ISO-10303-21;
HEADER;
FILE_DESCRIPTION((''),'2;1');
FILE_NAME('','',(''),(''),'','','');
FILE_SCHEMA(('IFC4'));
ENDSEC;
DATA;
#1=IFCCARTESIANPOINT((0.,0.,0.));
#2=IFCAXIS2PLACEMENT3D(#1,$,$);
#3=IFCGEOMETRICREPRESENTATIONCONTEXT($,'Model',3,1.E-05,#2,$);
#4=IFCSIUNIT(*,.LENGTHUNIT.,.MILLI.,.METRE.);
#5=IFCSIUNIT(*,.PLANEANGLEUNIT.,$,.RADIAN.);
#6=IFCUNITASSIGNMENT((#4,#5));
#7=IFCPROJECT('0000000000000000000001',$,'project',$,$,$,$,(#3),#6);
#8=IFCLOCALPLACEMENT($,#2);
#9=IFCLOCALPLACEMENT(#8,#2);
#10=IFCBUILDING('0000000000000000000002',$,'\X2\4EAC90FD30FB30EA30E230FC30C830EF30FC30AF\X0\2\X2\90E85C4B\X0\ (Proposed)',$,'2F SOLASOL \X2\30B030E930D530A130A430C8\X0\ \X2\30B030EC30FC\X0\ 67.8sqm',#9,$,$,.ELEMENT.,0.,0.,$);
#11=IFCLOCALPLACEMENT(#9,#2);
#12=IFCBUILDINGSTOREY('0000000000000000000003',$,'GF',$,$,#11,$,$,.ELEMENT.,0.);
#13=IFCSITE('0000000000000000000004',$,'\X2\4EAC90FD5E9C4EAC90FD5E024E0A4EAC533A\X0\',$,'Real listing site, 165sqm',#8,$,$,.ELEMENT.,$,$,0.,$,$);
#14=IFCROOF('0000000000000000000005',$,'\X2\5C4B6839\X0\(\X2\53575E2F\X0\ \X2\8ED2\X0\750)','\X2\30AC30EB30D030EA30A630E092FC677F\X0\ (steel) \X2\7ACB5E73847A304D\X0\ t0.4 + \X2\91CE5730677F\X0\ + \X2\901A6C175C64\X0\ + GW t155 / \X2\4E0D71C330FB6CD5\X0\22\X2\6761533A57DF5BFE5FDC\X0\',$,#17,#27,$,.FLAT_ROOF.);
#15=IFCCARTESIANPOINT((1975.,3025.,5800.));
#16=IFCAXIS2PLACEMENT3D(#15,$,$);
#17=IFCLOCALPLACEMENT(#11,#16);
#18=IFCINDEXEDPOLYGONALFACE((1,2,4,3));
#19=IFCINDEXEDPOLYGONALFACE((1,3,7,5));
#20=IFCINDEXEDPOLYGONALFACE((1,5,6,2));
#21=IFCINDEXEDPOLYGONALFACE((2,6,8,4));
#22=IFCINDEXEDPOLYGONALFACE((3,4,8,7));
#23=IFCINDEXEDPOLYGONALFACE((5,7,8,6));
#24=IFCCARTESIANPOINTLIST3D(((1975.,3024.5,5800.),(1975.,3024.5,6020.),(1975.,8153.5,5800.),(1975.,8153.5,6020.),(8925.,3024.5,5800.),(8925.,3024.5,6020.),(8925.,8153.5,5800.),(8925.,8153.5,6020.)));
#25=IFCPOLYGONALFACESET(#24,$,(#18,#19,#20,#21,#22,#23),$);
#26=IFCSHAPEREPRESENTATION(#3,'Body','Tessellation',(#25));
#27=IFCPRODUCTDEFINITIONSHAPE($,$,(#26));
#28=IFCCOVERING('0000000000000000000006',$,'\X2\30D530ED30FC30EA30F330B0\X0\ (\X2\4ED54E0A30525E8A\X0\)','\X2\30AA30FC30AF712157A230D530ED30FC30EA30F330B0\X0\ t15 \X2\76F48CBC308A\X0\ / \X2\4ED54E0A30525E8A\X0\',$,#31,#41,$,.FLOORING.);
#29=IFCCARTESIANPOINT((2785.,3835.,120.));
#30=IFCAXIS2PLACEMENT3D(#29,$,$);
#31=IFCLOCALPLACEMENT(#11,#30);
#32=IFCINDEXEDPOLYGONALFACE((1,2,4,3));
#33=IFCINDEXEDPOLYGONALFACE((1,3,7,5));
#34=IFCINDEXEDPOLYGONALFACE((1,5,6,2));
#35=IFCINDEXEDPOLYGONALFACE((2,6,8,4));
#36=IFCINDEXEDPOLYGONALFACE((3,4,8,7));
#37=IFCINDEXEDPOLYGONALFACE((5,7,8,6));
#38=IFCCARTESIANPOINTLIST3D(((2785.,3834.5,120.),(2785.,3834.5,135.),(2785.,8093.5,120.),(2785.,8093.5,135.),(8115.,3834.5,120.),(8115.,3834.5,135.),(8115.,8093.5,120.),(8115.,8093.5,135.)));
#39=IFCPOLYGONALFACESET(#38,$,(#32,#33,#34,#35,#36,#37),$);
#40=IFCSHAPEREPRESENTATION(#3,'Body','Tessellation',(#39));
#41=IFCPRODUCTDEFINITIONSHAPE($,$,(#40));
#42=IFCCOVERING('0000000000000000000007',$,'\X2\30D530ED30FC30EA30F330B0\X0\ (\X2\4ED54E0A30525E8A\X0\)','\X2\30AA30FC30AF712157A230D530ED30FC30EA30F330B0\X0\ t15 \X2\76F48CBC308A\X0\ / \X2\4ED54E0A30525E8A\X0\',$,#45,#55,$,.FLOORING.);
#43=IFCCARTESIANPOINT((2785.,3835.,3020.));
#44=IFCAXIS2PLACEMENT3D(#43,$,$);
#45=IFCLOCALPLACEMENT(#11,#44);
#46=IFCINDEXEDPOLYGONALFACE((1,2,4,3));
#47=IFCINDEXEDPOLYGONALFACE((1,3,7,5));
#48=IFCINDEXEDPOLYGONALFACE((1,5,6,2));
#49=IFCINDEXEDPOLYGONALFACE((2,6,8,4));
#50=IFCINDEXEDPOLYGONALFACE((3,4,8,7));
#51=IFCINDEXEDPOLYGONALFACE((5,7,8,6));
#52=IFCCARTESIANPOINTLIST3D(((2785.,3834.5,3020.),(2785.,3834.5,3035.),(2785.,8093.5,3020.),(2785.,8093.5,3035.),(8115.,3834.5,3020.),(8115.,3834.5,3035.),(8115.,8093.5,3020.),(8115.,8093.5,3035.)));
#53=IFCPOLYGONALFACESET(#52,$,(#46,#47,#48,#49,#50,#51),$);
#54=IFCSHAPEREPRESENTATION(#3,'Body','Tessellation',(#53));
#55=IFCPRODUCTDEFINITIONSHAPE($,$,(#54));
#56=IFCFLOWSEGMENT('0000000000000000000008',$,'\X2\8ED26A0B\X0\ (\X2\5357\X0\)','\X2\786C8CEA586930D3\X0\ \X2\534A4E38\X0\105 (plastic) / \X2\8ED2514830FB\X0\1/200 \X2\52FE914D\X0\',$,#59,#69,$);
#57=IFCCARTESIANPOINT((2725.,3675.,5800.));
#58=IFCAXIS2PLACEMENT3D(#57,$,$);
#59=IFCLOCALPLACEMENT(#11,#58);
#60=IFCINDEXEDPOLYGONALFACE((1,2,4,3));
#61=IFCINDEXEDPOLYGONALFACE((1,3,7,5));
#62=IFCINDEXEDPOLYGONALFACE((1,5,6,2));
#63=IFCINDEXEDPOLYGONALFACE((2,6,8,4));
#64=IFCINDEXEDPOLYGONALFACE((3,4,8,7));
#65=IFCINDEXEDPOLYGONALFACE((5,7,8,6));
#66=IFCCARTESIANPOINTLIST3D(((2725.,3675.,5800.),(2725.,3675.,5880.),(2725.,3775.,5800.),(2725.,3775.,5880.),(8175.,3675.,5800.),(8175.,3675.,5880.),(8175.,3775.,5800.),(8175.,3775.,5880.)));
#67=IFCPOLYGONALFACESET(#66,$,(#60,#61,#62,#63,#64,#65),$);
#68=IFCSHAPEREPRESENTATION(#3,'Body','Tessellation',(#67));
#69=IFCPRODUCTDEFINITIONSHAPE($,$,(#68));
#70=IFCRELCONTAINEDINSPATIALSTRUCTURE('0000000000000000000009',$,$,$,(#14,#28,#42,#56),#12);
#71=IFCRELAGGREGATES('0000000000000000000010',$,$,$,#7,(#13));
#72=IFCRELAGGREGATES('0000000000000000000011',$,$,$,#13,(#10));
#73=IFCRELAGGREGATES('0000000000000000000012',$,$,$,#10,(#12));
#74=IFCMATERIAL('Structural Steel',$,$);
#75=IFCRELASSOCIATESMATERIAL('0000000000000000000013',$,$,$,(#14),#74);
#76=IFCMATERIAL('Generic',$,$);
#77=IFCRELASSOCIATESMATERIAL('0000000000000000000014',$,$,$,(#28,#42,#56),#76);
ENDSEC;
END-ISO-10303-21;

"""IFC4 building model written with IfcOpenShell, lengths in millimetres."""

from ifc_helpers import new_model, si_unit, frame, frame_2d, origin, place, context, project, spatial, rectangle, extrude, material, element, save


model = new_model("IFC4")

# Units and contexts
model_context = context("Model", 3, precision=1e-05, world=origin())
ifc_project = project(units=[si_unit("LENGTHUNIT", "METRE", prefix="MILLI"), si_unit("PLANEANGLEUNIT", "RADIAN")], contexts=[model_context])

# Site, building, storey
site_placement = place(None, origin())
site = spatial("IfcSite", under=ifc_project, at=site_placement, Name="京都府京都市上京区", ObjectType="Real listing site, 165sqm", CompositionType="ELEMENT", RefElevation=0.0)
building_placement = place(site_placement, origin())
building = spatial("IfcBuilding", under=site, at=building_placement, Name="京都・リモートワーク2部屋 (Proposed)", ObjectType="2F SOLASOL グラファイト グレー 67.8sqm", CompositionType="ELEMENT", ElevationOfRefHeight=0.0, ElevationOfTerrain=0.0)
storey_placement = place(building_placement, origin())
storey = spatial("IfcBuildingStorey", under=building, at=storey_placement, Name="GF", CompositionType="ELEMENT", Elevation=0.0)

# Roof
ifc_material_1 = material(Name="Structural Steel")
for number, where, name in (
    (1, (1975.0, 3025.0, 5800.0), "屋根(南帯 軒750)"),
):
    element("IfcRoof", number, at=place(storey_placement, frame(where)), inside=storey, material=ifc_material_1, Name=name, Description="ガルバリウム鋼板 (steel) 立平葺き t0.4 + 野地板 + 通気層 + GW t155 / 不燃・法22条区域対応", PredefinedType="FLAT_ROOF", context=model_context, shape_type="SweptSolid", body=[
        extrude(rectangle(XDim=6950.0, YDim=5129.0, at=frame_2d((3475.0, 2564.0))), frame((1975.0, 3025.0, 5800.0)), (0.0, 0.0, 1.0), 220.0),
    ])

# Coverings
ifc_material_2 = material(Name="Generic")
covering_1_placement = place(storey_placement, frame((2785.0, 3835.0, 120.0)))
element("IfcCovering", 2, at=covering_1_placement, inside=storey, material=ifc_material_2, Name="フローリング (仕上げ床)", Description="オーク無垢フローリング t15 直貼り / 仕上げ床", PredefinedType="FLOORING", context=model_context, shape_type="SweptSolid", body=[
    extrude(rectangle(XDim=5330.0, YDim=4259.0, at=frame_2d((2665.0, 2129.0))), frame((2785.0, 3835.0, 120.0)), (0.0, 0.0, 1.0), 15.0),
])
covering_2_placement = place(storey_placement, frame((2785.0, 3835.0, 3020.0)))
element("IfcCovering", 3, at=covering_2_placement, inside=storey, material=ifc_material_2, Name="フローリング (仕上げ床)", Description="オーク無垢フローリング t15 直貼り / 仕上げ床", PredefinedType="FLOORING", context=model_context, shape_type="SweptSolid", body=[
    extrude(rectangle(XDim=5330.0, YDim=4259.0, at=frame_2d((2665.0, 2129.0))), frame((2785.0, 3835.0, 3020.0)), (0.0, 0.0, 1.0), 15.0),
])

# Flow segment
flow_segment_placement = place(storey_placement, frame((2725.0, 3675.0, 5800.0)))
element("IfcFlowSegment", 4, at=flow_segment_placement, inside=storey, material=ifc_material_2, Name="軒樋 (南)", Description="硬質塩ビ 半丸105 (plastic) / 軒先・1/200 勾配", context=model_context, shape_type="SweptSolid", body=[
    extrude(rectangle(XDim=5450.0, YDim=100.0, at=frame_2d((2725.0, 50.0))), frame((2725.0, 3675.0, 5800.0)), (0.0, 0.0, 1.0), 80.0),
])

save(model, "model.ifc")
